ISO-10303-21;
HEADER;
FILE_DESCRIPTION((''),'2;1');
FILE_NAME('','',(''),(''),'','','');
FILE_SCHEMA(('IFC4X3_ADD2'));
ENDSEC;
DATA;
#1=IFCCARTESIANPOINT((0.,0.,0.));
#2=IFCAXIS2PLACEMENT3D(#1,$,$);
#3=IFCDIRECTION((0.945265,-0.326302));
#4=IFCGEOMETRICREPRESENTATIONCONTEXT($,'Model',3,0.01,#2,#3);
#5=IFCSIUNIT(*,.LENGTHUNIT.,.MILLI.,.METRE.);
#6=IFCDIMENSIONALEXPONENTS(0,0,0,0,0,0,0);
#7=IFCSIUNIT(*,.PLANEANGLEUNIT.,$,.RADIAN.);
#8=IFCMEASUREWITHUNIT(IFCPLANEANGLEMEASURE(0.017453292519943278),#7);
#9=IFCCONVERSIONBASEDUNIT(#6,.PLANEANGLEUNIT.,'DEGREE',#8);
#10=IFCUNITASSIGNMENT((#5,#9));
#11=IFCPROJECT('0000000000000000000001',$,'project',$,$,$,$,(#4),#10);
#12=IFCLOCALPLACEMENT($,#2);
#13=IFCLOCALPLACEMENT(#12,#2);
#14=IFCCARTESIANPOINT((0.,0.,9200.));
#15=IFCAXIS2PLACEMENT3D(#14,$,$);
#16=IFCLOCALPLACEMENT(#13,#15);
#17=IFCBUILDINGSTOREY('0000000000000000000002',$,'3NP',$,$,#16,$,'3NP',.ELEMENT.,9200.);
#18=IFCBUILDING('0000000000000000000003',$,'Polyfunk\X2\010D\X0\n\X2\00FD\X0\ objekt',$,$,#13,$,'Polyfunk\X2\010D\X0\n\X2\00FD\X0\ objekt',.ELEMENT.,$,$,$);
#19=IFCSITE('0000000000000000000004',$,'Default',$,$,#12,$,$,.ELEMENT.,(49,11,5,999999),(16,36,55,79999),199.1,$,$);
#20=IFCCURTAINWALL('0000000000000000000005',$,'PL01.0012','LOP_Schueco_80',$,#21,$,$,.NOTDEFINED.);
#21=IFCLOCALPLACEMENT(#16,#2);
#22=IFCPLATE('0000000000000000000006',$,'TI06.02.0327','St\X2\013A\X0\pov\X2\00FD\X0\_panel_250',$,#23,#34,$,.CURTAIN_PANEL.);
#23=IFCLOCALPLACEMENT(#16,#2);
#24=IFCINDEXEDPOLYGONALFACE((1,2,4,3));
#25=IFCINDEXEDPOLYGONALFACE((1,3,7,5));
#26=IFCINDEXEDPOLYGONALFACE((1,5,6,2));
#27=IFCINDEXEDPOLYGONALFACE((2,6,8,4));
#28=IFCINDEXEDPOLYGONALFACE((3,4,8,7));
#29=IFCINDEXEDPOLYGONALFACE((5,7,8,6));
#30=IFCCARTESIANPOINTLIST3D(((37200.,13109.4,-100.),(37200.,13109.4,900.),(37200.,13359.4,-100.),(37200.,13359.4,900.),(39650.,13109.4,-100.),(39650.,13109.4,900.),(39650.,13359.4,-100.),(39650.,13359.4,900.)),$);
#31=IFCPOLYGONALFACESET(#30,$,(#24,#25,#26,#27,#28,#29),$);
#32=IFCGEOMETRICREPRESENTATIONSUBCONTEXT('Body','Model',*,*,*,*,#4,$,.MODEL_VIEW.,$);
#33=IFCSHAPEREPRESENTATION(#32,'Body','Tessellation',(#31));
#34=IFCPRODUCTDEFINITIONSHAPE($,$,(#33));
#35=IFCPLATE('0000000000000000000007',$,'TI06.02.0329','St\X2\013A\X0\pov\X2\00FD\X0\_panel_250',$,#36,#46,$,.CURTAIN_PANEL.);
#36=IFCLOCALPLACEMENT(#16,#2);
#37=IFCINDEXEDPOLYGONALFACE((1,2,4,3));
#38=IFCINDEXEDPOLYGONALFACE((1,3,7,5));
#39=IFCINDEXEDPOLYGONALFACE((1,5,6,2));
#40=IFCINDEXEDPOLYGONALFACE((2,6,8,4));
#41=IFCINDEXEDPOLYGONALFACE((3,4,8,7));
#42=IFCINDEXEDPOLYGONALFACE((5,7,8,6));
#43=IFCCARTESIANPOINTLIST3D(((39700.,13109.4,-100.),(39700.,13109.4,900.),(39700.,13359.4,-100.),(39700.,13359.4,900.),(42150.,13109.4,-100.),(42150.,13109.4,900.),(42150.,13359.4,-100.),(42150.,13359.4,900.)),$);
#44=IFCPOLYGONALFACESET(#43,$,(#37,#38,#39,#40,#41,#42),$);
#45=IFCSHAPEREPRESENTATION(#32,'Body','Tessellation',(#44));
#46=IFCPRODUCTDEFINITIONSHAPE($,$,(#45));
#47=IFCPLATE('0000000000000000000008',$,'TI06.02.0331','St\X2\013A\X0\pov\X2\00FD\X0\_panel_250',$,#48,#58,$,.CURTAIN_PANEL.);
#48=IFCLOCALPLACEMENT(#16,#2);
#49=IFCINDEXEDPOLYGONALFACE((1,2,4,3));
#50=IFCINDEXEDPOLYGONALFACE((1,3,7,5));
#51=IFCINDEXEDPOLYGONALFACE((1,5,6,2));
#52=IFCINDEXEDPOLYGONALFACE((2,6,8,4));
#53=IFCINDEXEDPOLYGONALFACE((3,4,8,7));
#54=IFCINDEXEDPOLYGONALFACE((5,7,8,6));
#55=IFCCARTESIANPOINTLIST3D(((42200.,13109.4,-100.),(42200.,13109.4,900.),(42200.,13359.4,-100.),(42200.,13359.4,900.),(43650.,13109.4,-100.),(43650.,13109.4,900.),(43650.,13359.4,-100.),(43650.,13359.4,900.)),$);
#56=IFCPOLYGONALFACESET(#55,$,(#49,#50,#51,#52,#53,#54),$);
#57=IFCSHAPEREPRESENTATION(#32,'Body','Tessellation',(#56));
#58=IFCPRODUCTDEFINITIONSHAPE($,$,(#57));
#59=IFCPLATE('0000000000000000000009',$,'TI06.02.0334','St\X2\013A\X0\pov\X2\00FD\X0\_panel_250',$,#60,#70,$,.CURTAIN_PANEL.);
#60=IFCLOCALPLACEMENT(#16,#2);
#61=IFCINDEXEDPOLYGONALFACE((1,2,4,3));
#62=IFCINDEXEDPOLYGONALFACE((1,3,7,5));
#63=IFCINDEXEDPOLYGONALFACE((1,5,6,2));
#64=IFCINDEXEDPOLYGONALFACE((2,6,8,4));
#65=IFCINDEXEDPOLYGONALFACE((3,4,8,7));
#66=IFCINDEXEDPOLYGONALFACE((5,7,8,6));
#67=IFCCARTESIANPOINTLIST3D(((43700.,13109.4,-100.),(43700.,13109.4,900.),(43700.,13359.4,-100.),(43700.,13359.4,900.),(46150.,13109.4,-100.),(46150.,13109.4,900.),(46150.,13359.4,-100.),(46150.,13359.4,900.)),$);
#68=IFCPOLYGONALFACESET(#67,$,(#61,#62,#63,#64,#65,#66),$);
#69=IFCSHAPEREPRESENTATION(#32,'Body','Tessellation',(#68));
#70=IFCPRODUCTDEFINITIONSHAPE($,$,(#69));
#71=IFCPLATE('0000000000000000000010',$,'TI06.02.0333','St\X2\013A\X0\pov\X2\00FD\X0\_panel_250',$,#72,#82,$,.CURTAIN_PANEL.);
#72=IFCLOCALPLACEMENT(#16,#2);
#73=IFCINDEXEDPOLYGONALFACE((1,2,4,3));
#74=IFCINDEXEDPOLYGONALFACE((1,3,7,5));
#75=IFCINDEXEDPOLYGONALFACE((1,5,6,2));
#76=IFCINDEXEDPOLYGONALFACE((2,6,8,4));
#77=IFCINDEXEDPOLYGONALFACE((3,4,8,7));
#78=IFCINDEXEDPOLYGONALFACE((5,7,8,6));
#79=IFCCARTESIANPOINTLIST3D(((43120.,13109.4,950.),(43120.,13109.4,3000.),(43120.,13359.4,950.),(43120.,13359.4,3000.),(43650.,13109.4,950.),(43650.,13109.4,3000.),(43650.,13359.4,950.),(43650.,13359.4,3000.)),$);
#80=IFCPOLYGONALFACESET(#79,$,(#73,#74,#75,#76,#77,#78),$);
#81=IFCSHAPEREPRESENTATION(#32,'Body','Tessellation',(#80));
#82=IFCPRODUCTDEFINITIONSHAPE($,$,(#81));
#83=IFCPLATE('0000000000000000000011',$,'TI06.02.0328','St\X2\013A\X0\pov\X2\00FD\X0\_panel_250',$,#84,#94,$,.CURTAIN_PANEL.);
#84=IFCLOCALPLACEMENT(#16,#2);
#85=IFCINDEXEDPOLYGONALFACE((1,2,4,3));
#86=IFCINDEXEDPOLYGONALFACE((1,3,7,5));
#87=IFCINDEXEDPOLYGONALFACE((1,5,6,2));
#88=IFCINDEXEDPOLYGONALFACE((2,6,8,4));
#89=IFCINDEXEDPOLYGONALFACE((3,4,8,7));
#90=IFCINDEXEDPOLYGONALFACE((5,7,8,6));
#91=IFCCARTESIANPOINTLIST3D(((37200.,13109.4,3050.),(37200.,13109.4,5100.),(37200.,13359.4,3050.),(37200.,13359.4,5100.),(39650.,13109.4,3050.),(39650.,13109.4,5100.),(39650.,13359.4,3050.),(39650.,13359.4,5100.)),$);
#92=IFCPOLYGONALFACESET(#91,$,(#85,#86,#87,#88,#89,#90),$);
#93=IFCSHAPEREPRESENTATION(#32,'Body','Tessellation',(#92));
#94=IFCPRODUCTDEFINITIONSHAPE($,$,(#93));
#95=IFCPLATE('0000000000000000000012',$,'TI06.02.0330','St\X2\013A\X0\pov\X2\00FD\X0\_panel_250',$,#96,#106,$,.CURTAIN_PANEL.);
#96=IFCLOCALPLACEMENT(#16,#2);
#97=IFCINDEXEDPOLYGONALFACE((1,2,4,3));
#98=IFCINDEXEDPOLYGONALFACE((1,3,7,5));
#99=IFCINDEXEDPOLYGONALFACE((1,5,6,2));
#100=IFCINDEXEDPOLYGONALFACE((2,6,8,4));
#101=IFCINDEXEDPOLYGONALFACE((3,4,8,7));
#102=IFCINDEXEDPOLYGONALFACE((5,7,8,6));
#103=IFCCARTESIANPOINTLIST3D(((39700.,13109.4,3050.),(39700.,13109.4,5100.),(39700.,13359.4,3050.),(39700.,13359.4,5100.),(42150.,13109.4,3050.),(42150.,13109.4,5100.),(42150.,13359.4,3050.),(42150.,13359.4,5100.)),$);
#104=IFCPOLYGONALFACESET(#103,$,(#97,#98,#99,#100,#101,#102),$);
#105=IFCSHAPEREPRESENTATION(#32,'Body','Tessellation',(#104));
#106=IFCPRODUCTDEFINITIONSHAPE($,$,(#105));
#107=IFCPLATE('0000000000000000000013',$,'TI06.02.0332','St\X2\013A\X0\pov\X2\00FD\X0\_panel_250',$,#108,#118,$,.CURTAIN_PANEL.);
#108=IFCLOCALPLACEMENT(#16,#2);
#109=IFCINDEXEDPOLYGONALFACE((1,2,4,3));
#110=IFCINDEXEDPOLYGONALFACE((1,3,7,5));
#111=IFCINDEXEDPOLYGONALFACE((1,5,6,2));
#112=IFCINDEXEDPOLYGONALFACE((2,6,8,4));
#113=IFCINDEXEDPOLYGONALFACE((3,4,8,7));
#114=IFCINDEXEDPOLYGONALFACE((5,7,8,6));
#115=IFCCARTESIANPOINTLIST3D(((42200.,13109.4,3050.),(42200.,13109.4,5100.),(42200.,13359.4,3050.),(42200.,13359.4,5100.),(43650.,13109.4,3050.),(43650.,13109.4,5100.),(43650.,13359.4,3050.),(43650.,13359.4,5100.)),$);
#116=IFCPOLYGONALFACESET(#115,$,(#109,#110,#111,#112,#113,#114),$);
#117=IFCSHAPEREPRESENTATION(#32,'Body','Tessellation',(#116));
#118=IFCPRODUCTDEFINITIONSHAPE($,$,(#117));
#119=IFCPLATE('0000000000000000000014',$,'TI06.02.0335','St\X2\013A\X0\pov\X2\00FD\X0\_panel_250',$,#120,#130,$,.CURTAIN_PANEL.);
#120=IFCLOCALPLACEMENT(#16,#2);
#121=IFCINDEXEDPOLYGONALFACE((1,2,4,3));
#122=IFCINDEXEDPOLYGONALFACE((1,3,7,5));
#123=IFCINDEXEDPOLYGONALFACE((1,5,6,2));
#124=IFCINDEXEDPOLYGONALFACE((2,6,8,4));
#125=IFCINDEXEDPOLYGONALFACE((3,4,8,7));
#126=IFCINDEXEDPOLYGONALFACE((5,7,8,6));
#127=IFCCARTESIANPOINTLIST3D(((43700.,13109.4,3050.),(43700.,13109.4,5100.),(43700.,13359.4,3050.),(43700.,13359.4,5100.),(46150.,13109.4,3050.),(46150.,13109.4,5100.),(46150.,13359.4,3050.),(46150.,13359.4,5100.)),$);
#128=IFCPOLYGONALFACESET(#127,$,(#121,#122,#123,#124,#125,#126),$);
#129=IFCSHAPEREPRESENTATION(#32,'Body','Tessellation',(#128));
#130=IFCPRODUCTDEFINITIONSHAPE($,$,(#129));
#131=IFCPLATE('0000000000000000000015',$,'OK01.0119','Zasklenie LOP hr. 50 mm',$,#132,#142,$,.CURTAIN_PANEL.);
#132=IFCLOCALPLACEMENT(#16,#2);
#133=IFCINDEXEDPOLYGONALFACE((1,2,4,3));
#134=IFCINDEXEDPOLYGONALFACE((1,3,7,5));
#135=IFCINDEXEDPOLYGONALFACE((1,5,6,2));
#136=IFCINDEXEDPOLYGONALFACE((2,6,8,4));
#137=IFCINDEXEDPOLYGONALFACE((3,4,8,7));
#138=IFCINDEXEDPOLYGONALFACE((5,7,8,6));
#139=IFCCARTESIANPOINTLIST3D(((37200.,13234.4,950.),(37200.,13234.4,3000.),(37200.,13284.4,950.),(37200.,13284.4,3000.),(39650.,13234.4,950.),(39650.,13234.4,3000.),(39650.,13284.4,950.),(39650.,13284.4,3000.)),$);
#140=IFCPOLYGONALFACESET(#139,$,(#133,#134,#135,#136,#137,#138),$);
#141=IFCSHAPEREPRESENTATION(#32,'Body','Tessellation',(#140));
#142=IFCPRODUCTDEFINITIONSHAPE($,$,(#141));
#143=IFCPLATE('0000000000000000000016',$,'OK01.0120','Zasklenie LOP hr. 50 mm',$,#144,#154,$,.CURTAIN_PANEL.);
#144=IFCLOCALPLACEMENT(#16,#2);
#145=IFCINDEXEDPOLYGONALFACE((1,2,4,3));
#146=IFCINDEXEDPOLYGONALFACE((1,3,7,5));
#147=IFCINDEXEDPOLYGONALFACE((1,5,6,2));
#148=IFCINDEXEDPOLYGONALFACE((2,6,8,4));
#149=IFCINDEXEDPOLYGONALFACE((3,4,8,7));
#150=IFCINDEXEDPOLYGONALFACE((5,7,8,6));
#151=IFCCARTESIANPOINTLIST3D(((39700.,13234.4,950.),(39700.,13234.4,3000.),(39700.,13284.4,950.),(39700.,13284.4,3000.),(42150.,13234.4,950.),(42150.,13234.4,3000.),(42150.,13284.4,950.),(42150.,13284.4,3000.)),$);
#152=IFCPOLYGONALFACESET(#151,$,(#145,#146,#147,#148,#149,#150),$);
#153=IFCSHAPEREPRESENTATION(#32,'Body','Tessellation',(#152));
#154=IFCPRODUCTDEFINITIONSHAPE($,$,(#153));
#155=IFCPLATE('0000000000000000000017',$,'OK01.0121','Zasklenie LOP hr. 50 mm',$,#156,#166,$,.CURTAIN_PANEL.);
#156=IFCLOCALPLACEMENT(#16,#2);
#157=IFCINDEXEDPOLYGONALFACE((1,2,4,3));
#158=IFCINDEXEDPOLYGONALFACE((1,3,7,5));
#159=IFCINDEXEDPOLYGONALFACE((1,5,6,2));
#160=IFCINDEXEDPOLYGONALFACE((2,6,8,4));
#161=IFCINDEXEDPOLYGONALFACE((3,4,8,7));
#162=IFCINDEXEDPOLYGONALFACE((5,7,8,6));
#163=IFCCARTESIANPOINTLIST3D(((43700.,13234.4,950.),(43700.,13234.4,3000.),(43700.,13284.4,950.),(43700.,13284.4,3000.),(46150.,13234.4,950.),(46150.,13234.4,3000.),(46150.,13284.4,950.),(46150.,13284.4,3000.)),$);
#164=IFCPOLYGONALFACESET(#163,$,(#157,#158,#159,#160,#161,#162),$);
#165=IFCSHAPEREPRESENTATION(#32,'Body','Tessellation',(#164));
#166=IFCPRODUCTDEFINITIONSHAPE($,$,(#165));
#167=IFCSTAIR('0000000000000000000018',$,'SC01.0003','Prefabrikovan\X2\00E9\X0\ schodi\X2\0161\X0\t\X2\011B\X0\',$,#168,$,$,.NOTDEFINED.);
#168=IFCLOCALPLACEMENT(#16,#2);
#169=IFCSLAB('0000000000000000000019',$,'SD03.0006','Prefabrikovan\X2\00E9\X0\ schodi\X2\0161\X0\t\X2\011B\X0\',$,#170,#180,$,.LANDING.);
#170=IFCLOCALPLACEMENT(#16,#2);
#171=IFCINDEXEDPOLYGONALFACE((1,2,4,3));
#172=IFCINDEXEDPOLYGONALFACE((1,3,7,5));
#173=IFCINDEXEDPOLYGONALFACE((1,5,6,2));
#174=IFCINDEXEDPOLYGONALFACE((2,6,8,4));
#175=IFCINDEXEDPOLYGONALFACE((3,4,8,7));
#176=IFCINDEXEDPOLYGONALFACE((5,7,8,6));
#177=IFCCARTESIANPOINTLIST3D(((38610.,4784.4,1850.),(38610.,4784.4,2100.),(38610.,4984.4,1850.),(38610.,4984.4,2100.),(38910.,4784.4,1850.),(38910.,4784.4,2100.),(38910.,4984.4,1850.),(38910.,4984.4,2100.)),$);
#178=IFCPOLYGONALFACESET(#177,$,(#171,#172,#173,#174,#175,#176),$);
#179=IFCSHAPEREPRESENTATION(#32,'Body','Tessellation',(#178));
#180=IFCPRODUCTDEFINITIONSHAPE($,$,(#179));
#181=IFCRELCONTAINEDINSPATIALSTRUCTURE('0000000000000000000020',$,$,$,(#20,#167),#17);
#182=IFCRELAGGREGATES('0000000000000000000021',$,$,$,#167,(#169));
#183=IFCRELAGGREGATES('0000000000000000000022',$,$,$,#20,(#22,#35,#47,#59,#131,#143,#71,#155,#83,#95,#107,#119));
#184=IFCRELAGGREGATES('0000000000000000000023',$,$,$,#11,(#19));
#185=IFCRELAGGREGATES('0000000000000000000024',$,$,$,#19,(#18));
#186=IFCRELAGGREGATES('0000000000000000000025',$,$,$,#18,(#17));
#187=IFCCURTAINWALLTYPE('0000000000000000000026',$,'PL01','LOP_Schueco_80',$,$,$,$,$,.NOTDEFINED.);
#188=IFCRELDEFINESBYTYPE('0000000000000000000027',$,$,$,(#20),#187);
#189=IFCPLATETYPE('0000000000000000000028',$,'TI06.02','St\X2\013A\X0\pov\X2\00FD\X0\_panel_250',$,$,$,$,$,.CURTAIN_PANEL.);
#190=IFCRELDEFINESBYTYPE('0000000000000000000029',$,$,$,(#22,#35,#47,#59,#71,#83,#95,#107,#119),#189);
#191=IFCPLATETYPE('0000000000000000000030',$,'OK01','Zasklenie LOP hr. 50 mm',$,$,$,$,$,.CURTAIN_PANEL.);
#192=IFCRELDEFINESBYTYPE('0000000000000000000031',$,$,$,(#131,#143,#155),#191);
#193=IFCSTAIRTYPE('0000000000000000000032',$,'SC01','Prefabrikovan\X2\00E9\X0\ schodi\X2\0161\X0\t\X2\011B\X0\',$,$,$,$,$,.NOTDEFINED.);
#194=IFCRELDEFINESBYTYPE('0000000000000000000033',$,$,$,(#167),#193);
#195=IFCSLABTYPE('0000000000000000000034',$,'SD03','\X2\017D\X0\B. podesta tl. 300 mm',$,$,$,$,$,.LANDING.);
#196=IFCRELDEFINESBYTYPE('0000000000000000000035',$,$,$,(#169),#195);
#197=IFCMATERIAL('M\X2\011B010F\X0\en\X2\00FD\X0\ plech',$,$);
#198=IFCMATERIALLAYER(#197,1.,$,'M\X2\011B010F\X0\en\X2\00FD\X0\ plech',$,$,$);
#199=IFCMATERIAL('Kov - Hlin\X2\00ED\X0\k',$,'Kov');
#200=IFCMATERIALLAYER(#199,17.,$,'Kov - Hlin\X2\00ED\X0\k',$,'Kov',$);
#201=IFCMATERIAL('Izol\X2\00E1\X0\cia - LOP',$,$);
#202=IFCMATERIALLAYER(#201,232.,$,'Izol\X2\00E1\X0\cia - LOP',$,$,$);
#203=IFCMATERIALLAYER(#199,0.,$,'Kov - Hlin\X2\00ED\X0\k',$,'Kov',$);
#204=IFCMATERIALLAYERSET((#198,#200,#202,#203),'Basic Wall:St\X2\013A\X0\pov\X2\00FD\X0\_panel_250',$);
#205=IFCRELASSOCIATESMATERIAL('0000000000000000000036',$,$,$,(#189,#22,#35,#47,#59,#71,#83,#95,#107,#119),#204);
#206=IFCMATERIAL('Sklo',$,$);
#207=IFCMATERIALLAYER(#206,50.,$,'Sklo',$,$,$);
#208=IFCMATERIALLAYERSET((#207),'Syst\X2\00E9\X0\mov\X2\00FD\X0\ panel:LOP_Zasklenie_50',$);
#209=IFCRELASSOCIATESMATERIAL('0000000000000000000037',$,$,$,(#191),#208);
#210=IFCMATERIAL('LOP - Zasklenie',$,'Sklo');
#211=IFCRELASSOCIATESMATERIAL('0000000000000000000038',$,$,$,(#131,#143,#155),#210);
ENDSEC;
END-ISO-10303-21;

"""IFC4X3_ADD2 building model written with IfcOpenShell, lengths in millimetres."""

from ifc_helpers import new_model, entity, si_unit, converted_unit, direction, frame, frame_2d, origin, origin_2d_with_axis, place, context, subcontext, project, spatial, rectangle, extrude, source, transform, mapped, material, layer, layer_set, layer_usage, type_object, type_shapes, element, aggregate, save


model = new_model("IFC4X3_ADD2")

# Units and contexts
model_context = context("Model", 3, precision=0.01, world=origin(), true_north=direction((0.945265, -0.326302)))
body_context = subcontext(model_context, "Body", "Model", "MODEL_VIEW")
ifc_project = project(units=[si_unit("LENGTHUNIT", "METRE", prefix="MILLI"), converted_unit("PLANEANGLEUNIT", "DEGREE", entity("IfcPlaneAngleMeasure", 0.017453292519943278), si_unit("PLANEANGLEUNIT", "RADIAN"), dimensions=[0, 0, 0, 0, 0, 0, 0])], contexts=[model_context])

# Site, building, storey
site_placement = place(None, origin())
site = spatial("IfcSite", under=ifc_project, at=site_placement, Name="Default", CompositionType="ELEMENT", RefLatitude=(49, 11, 5, 999999), RefLongitude=(16, 36, 55, 79999), RefElevation=199.1)
building_placement = place(site_placement, origin())
building = spatial("IfcBuilding", under=site, at=building_placement, Name="Polyfunkčný objekt", LongName="Polyfunkčný objekt", CompositionType="ELEMENT")
storey_placement = place(building_placement, frame((0.0, 0.0, 9200.0)))
storey = spatial("IfcBuildingStorey", under=building, at=storey_placement, Name="3NP", LongName="3NP", CompositionType="ELEMENT", Elevation=9200.0)

# Curtain wall, plates
curtain_wall_type = type_object("IfcCurtainWallType", Name="PL01", Description="LOP_Schueco_80", PredefinedType="NOTDEFINED")
curtain_wall_placement = place(storey_placement, frame((0.0, 0.0, -9200.0)))
curtain_wall = element("IfcCurtainWall", 1, at=curtain_wall_placement, inside=storey, type_object=curtain_wall_type, Name="PL01.0012", Description="LOP_Schueco_80", PredefinedType="NOTDEFINED")
ifc_material_1 = material(Name="Měďený plech")
ifc_layer_1 = layer(ifc_material_1, 1.0, Name="Měďený plech")
ifc_material_2 = material(Name="Kov - Hliník", Category="Kov")
ifc_layer_2 = layer(ifc_material_2, 17.0, Name="Kov - Hliník", Category="Kov")
ifc_material_3 = material(Name="Izolácia - LOP")
ifc_layer_3 = layer(ifc_material_3, 232.0, Name="Izolácia - LOP")
ifc_layer_4 = layer(ifc_material_2, 0.0, Name="Kov - Hliník", Category="Kov")
ifc_layer_set_1 = layer_set([ifc_layer_1, ifc_layer_2, ifc_layer_3, ifc_layer_4], Name="Basic Wall:Stĺpový_panel_250")
ifc_layer_usage_1 = layer_usage(ifc_layer_set_1, "AXIS2", "NEGATIVE", 125.0)
plate_type_1 = type_object("IfcPlateType", Name="TI06.02", Description="Stĺpový_panel_250", PredefinedType="CURTAIN_PANEL", material=ifc_layer_set_1)
plate_1_placement = place(storey_placement, frame((37200.0, 13234.4, -100.0)))
plate_1 = element("IfcPlate", 2, at=plate_1_placement, type_object=plate_type_1, material=ifc_layer_usage_1, Name="TI06.02.0327", Description="Stĺpový_panel_250", PredefinedType="CURTAIN_PANEL", context=body_context, shape_type="SweptSolid", body=[
    extrude(rectangle(XDim=250.0, YDim=2450.0, at=frame_2d((0.0, 0.0), x_axis=(1.0, 0.0))), frame((1225.0, 0.0, 0.0), z_axis=(0.0, 0.0, 1.0), x_axis=(0.0, 1.0, 0.0)), (0.0, 0.0, 1.0), 1000.0),
])
ifc_layer_usage_2 = layer_usage(ifc_layer_set_1, "AXIS2", "NEGATIVE", 125.0)
plate_2_placement = place(storey_placement, frame((39700.0, 13234.4, -100.0)))
plate_2 = element("IfcPlate", 3, at=plate_2_placement, type_object=plate_type_1, material=ifc_layer_usage_2, Name="TI06.02.0329", Description="Stĺpový_panel_250", PredefinedType="CURTAIN_PANEL", context=body_context, shape_type="SweptSolid", body=[
    extrude(rectangle(XDim=250.0, YDim=2450.0, at=frame_2d((0.0, 0.0), x_axis=(1.0, 0.0))), frame((1225.0, 0.0, 0.0), z_axis=(0.0, 0.0, 1.0), x_axis=(0.0, 1.0, 0.0)), (0.0, 0.0, 1.0), 1000.0),
])
ifc_layer_usage_3 = layer_usage(ifc_layer_set_1, "AXIS2", "NEGATIVE", 125.0)
plate_3_placement = place(storey_placement, frame((42200.0, 13234.4, -100.0)))
plate_3 = element("IfcPlate", 4, at=plate_3_placement, type_object=plate_type_1, material=ifc_layer_usage_3, Name="TI06.02.0331", Description="Stĺpový_panel_250", PredefinedType="CURTAIN_PANEL", context=body_context, shape_type="SweptSolid", body=[
    extrude(rectangle(XDim=250.0, YDim=1450.0, at=frame_2d((0.0, 0.0), x_axis=(1.0, 0.0))), frame((725.0, 0.0, 0.0), z_axis=(0.0, 0.0, 1.0), x_axis=(0.0, 1.0, 0.0)), (0.0, 0.0, 1.0), 1000.0),
])
ifc_layer_usage_4 = layer_usage(ifc_layer_set_1, "AXIS2", "NEGATIVE", 125.0)
plate_4_placement = place(storey_placement, frame((43700.0, 13234.4, -100.0)))
plate_4 = element("IfcPlate", 5, at=plate_4_placement, type_object=plate_type_1, material=ifc_layer_usage_4, Name="TI06.02.0334", Description="Stĺpový_panel_250", PredefinedType="CURTAIN_PANEL", context=body_context, shape_type="SweptSolid", body=[
    extrude(rectangle(XDim=250.0, YDim=2450.0, at=frame_2d((0.0, 0.0), x_axis=(1.0, 0.0))), frame((1225.0, 0.0, 0.0), z_axis=(0.0, 0.0, 1.0), x_axis=(0.0, 1.0, 0.0)), (0.0, 0.0, 1.0), 1000.0),
])
ifc_layer_usage_5 = layer_usage(ifc_layer_set_1, "AXIS2", "NEGATIVE", 125.0)
plate_5_placement = place(storey_placement, frame((43120.0, 13234.4, 950.0)))
plate_5 = element("IfcPlate", 6, at=plate_5_placement, type_object=plate_type_1, material=ifc_layer_usage_5, Name="TI06.02.0333", Description="Stĺpový_panel_250", PredefinedType="CURTAIN_PANEL", context=body_context, shape_type="SweptSolid", body=[
    extrude(rectangle(XDim=250.0, YDim=530.0, at=frame_2d((0.0, 0.0), x_axis=(1.0, 0.0))), frame((265.0, 0.0, 0.0), z_axis=(0.0, 0.0, 1.0), x_axis=(0.0, 1.0, 0.0)), (0.0, 0.0, 1.0), 2050.0),
])
ifc_layer_usage_6 = layer_usage(ifc_layer_set_1, "AXIS2", "NEGATIVE", 125.0)
plate_6_placement = place(storey_placement, frame((37200.0, 13234.4, 3050.0)))
plate_6 = element("IfcPlate", 7, at=plate_6_placement, type_object=plate_type_1, material=ifc_layer_usage_6, Name="TI06.02.0328", Description="Stĺpový_panel_250", PredefinedType="CURTAIN_PANEL", context=body_context, shape_type="SweptSolid", body=[
    extrude(rectangle(XDim=250.0, YDim=2450.0, at=frame_2d((0.0, 0.0), x_axis=(1.0, 0.0))), frame((1225.0, 0.0, 0.0), z_axis=(0.0, 0.0, 1.0), x_axis=(0.0, 1.0, 0.0)), (0.0, 0.0, 1.0), 2050.0),
])
ifc_layer_usage_7 = layer_usage(ifc_layer_set_1, "AXIS2", "NEGATIVE", 125.0)
plate_7_placement = place(storey_placement, frame((39700.0, 13234.4, 3050.0)))
plate_7 = element("IfcPlate", 8, at=plate_7_placement, type_object=plate_type_1, material=ifc_layer_usage_7, Name="TI06.02.0330", Description="Stĺpový_panel_250", PredefinedType="CURTAIN_PANEL", context=body_context, shape_type="SweptSolid", body=[
    extrude(rectangle(XDim=250.0, YDim=2450.0, at=frame_2d((0.0, 0.0), x_axis=(1.0, 0.0))), frame((1225.0, 0.0, 0.0), z_axis=(0.0, 0.0, 1.0), x_axis=(0.0, 1.0, 0.0)), (0.0, 0.0, 1.0), 2050.0),
])
ifc_layer_usage_8 = layer_usage(ifc_layer_set_1, "AXIS2", "NEGATIVE", 125.0)
plate_8_placement = place(storey_placement, frame((42200.0, 13234.4, 3050.0)))
plate_8 = element("IfcPlate", 9, at=plate_8_placement, type_object=plate_type_1, material=ifc_layer_usage_8, Name="TI06.02.0332", Description="Stĺpový_panel_250", PredefinedType="CURTAIN_PANEL", context=body_context, shape_type="SweptSolid", body=[
    extrude(rectangle(XDim=250.0, YDim=1450.0, at=frame_2d((0.0, 0.0), x_axis=(1.0, 0.0))), frame((725.0, 0.0, 0.0), z_axis=(0.0, 0.0, 1.0), x_axis=(0.0, 1.0, 0.0)), (0.0, 0.0, 1.0), 2050.0),
])
ifc_layer_usage_9 = layer_usage(ifc_layer_set_1, "AXIS2", "NEGATIVE", 125.0)
plate_9_placement = place(storey_placement, frame((43700.0, 13234.4, 3050.0)))
plate_9 = element("IfcPlate", 10, at=plate_9_placement, type_object=plate_type_1, material=ifc_layer_usage_9, Name="TI06.02.0335", Description="Stĺpový_panel_250", PredefinedType="CURTAIN_PANEL", context=body_context, shape_type="SweptSolid", body=[
    extrude(rectangle(XDim=250.0, YDim=2450.0, at=frame_2d((0.0, 0.0), x_axis=(1.0, 0.0))), frame((1225.0, 0.0, 0.0), z_axis=(0.0, 0.0, 1.0), x_axis=(0.0, 1.0, 0.0)), (0.0, 0.0, 1.0), 2050.0),
])
ifc_material_4 = material(Name="LOP - Zasklenie", Category="Sklo")
ifc_material_5 = material(Name="Sklo")
ifc_layer_5 = layer(ifc_material_5, 50.0, Name="Sklo")
ifc_layer_set_2 = layer_set([ifc_layer_5], Name="Systémový panel:LOP_Zasklenie_50")
plate_type_2 = type_object("IfcPlateType", Name="OK01", Description="Zasklenie LOP hr. 50 mm", PredefinedType="CURTAIN_PANEL", material=ifc_layer_set_2)
shared_shape_1 = source(origin(), body_context, "Body", "SweptSolid", [
    extrude(rectangle(XDim=50.0, YDim=2450.0, at=origin_2d_with_axis()), frame((0.0, 25.0, 0.0), z_axis=(0.0, 0.0, 1.0), x_axis=(0.0, 1.0, 0.0)), (0.0, 0.0, 1.0), 2050.0),
])
type_shapes(plate_type_2, [shared_shape_1])
plate_10_placement = place(curtain_wall_placement, frame((38425.0, 13234.4, 10150.0)))
plate_10 = element("IfcPlate", 11, at=plate_10_placement, type_object=plate_type_2, material=ifc_material_4, Name="OK01.0119", Description="Zasklenie LOP hr. 50 mm", PredefinedType="CURTAIN_PANEL", context=body_context, shape_type="MappedRepresentation", body=[
    mapped(shared_shape_1, transform((0.0, 0.0, 0.0), scale=1.0)),
])
plate_11_placement = place(curtain_wall_placement, frame((40925.0, 13234.4, 10150.0)))
plate_11 = element("IfcPlate", 12, at=plate_11_placement, type_object=plate_type_2, material=ifc_material_4, Name="OK01.0120", Description="Zasklenie LOP hr. 50 mm", PredefinedType="CURTAIN_PANEL", context=body_context, shape_type="MappedRepresentation", body=[
    mapped(shared_shape_1, transform((0.0, 0.0, 0.0), scale=1.0)),
])
plate_12_placement = place(curtain_wall_placement, frame((44925.0, 13234.4, 10150.0)))
plate_12 = element("IfcPlate", 13, at=plate_12_placement, type_object=plate_type_2, material=ifc_material_4, Name="OK01.0121", Description="Zasklenie LOP hr. 50 mm", PredefinedType="CURTAIN_PANEL", context=body_context, shape_type="MappedRepresentation", body=[
    mapped(shared_shape_1, transform((0.0, 0.0, 0.0), scale=1.0)),
])

# Stair, slab
stair_type = type_object("IfcStairType", Name="SC01", Description="Prefabrikované schodiště", PredefinedType="NOTDEFINED")
stair_placement = place(storey_placement, origin())
stair = element("IfcStair", 14, at=stair_placement, inside=storey, type_object=stair_type, Name="SC01.0003", Description="Prefabrikované schodiště", PredefinedType="NOTDEFINED")
slab_type = type_object("IfcSlabType", Name="SD03", Description="ŽB. podesta tl. 300 mm", PredefinedType="LANDING")
slab_placement = place(stair_placement, frame((38610.0, 4784.4, 0.0)))
slab = element("IfcSlab", 15, at=slab_placement, type_object=slab_type, Name="SD03.0006", Description="Prefabrikované schodiště", PredefinedType="LANDING", context=body_context, shape_type="SweptSolid", body=[
    extrude(rectangle(XDim=200.0, YDim=300.0, at=frame_2d((0.0, 0.0), x_axis=(1.0, 0.0))), frame((150.0, 100.0, 1850.0), z_axis=(0.0, 0.0, 1.0), x_axis=(0.0, 1.0, 0.0)), (0.0, 0.0, 1.0), 250.0),
])
aggregate(stair, [slab])

aggregate(curtain_wall, [plate_1, plate_2, plate_3, plate_4, plate_10, plate_11, plate_5, plate_12, plate_6, plate_7, plate_8, plate_9])

save(model, "model.ifc")
